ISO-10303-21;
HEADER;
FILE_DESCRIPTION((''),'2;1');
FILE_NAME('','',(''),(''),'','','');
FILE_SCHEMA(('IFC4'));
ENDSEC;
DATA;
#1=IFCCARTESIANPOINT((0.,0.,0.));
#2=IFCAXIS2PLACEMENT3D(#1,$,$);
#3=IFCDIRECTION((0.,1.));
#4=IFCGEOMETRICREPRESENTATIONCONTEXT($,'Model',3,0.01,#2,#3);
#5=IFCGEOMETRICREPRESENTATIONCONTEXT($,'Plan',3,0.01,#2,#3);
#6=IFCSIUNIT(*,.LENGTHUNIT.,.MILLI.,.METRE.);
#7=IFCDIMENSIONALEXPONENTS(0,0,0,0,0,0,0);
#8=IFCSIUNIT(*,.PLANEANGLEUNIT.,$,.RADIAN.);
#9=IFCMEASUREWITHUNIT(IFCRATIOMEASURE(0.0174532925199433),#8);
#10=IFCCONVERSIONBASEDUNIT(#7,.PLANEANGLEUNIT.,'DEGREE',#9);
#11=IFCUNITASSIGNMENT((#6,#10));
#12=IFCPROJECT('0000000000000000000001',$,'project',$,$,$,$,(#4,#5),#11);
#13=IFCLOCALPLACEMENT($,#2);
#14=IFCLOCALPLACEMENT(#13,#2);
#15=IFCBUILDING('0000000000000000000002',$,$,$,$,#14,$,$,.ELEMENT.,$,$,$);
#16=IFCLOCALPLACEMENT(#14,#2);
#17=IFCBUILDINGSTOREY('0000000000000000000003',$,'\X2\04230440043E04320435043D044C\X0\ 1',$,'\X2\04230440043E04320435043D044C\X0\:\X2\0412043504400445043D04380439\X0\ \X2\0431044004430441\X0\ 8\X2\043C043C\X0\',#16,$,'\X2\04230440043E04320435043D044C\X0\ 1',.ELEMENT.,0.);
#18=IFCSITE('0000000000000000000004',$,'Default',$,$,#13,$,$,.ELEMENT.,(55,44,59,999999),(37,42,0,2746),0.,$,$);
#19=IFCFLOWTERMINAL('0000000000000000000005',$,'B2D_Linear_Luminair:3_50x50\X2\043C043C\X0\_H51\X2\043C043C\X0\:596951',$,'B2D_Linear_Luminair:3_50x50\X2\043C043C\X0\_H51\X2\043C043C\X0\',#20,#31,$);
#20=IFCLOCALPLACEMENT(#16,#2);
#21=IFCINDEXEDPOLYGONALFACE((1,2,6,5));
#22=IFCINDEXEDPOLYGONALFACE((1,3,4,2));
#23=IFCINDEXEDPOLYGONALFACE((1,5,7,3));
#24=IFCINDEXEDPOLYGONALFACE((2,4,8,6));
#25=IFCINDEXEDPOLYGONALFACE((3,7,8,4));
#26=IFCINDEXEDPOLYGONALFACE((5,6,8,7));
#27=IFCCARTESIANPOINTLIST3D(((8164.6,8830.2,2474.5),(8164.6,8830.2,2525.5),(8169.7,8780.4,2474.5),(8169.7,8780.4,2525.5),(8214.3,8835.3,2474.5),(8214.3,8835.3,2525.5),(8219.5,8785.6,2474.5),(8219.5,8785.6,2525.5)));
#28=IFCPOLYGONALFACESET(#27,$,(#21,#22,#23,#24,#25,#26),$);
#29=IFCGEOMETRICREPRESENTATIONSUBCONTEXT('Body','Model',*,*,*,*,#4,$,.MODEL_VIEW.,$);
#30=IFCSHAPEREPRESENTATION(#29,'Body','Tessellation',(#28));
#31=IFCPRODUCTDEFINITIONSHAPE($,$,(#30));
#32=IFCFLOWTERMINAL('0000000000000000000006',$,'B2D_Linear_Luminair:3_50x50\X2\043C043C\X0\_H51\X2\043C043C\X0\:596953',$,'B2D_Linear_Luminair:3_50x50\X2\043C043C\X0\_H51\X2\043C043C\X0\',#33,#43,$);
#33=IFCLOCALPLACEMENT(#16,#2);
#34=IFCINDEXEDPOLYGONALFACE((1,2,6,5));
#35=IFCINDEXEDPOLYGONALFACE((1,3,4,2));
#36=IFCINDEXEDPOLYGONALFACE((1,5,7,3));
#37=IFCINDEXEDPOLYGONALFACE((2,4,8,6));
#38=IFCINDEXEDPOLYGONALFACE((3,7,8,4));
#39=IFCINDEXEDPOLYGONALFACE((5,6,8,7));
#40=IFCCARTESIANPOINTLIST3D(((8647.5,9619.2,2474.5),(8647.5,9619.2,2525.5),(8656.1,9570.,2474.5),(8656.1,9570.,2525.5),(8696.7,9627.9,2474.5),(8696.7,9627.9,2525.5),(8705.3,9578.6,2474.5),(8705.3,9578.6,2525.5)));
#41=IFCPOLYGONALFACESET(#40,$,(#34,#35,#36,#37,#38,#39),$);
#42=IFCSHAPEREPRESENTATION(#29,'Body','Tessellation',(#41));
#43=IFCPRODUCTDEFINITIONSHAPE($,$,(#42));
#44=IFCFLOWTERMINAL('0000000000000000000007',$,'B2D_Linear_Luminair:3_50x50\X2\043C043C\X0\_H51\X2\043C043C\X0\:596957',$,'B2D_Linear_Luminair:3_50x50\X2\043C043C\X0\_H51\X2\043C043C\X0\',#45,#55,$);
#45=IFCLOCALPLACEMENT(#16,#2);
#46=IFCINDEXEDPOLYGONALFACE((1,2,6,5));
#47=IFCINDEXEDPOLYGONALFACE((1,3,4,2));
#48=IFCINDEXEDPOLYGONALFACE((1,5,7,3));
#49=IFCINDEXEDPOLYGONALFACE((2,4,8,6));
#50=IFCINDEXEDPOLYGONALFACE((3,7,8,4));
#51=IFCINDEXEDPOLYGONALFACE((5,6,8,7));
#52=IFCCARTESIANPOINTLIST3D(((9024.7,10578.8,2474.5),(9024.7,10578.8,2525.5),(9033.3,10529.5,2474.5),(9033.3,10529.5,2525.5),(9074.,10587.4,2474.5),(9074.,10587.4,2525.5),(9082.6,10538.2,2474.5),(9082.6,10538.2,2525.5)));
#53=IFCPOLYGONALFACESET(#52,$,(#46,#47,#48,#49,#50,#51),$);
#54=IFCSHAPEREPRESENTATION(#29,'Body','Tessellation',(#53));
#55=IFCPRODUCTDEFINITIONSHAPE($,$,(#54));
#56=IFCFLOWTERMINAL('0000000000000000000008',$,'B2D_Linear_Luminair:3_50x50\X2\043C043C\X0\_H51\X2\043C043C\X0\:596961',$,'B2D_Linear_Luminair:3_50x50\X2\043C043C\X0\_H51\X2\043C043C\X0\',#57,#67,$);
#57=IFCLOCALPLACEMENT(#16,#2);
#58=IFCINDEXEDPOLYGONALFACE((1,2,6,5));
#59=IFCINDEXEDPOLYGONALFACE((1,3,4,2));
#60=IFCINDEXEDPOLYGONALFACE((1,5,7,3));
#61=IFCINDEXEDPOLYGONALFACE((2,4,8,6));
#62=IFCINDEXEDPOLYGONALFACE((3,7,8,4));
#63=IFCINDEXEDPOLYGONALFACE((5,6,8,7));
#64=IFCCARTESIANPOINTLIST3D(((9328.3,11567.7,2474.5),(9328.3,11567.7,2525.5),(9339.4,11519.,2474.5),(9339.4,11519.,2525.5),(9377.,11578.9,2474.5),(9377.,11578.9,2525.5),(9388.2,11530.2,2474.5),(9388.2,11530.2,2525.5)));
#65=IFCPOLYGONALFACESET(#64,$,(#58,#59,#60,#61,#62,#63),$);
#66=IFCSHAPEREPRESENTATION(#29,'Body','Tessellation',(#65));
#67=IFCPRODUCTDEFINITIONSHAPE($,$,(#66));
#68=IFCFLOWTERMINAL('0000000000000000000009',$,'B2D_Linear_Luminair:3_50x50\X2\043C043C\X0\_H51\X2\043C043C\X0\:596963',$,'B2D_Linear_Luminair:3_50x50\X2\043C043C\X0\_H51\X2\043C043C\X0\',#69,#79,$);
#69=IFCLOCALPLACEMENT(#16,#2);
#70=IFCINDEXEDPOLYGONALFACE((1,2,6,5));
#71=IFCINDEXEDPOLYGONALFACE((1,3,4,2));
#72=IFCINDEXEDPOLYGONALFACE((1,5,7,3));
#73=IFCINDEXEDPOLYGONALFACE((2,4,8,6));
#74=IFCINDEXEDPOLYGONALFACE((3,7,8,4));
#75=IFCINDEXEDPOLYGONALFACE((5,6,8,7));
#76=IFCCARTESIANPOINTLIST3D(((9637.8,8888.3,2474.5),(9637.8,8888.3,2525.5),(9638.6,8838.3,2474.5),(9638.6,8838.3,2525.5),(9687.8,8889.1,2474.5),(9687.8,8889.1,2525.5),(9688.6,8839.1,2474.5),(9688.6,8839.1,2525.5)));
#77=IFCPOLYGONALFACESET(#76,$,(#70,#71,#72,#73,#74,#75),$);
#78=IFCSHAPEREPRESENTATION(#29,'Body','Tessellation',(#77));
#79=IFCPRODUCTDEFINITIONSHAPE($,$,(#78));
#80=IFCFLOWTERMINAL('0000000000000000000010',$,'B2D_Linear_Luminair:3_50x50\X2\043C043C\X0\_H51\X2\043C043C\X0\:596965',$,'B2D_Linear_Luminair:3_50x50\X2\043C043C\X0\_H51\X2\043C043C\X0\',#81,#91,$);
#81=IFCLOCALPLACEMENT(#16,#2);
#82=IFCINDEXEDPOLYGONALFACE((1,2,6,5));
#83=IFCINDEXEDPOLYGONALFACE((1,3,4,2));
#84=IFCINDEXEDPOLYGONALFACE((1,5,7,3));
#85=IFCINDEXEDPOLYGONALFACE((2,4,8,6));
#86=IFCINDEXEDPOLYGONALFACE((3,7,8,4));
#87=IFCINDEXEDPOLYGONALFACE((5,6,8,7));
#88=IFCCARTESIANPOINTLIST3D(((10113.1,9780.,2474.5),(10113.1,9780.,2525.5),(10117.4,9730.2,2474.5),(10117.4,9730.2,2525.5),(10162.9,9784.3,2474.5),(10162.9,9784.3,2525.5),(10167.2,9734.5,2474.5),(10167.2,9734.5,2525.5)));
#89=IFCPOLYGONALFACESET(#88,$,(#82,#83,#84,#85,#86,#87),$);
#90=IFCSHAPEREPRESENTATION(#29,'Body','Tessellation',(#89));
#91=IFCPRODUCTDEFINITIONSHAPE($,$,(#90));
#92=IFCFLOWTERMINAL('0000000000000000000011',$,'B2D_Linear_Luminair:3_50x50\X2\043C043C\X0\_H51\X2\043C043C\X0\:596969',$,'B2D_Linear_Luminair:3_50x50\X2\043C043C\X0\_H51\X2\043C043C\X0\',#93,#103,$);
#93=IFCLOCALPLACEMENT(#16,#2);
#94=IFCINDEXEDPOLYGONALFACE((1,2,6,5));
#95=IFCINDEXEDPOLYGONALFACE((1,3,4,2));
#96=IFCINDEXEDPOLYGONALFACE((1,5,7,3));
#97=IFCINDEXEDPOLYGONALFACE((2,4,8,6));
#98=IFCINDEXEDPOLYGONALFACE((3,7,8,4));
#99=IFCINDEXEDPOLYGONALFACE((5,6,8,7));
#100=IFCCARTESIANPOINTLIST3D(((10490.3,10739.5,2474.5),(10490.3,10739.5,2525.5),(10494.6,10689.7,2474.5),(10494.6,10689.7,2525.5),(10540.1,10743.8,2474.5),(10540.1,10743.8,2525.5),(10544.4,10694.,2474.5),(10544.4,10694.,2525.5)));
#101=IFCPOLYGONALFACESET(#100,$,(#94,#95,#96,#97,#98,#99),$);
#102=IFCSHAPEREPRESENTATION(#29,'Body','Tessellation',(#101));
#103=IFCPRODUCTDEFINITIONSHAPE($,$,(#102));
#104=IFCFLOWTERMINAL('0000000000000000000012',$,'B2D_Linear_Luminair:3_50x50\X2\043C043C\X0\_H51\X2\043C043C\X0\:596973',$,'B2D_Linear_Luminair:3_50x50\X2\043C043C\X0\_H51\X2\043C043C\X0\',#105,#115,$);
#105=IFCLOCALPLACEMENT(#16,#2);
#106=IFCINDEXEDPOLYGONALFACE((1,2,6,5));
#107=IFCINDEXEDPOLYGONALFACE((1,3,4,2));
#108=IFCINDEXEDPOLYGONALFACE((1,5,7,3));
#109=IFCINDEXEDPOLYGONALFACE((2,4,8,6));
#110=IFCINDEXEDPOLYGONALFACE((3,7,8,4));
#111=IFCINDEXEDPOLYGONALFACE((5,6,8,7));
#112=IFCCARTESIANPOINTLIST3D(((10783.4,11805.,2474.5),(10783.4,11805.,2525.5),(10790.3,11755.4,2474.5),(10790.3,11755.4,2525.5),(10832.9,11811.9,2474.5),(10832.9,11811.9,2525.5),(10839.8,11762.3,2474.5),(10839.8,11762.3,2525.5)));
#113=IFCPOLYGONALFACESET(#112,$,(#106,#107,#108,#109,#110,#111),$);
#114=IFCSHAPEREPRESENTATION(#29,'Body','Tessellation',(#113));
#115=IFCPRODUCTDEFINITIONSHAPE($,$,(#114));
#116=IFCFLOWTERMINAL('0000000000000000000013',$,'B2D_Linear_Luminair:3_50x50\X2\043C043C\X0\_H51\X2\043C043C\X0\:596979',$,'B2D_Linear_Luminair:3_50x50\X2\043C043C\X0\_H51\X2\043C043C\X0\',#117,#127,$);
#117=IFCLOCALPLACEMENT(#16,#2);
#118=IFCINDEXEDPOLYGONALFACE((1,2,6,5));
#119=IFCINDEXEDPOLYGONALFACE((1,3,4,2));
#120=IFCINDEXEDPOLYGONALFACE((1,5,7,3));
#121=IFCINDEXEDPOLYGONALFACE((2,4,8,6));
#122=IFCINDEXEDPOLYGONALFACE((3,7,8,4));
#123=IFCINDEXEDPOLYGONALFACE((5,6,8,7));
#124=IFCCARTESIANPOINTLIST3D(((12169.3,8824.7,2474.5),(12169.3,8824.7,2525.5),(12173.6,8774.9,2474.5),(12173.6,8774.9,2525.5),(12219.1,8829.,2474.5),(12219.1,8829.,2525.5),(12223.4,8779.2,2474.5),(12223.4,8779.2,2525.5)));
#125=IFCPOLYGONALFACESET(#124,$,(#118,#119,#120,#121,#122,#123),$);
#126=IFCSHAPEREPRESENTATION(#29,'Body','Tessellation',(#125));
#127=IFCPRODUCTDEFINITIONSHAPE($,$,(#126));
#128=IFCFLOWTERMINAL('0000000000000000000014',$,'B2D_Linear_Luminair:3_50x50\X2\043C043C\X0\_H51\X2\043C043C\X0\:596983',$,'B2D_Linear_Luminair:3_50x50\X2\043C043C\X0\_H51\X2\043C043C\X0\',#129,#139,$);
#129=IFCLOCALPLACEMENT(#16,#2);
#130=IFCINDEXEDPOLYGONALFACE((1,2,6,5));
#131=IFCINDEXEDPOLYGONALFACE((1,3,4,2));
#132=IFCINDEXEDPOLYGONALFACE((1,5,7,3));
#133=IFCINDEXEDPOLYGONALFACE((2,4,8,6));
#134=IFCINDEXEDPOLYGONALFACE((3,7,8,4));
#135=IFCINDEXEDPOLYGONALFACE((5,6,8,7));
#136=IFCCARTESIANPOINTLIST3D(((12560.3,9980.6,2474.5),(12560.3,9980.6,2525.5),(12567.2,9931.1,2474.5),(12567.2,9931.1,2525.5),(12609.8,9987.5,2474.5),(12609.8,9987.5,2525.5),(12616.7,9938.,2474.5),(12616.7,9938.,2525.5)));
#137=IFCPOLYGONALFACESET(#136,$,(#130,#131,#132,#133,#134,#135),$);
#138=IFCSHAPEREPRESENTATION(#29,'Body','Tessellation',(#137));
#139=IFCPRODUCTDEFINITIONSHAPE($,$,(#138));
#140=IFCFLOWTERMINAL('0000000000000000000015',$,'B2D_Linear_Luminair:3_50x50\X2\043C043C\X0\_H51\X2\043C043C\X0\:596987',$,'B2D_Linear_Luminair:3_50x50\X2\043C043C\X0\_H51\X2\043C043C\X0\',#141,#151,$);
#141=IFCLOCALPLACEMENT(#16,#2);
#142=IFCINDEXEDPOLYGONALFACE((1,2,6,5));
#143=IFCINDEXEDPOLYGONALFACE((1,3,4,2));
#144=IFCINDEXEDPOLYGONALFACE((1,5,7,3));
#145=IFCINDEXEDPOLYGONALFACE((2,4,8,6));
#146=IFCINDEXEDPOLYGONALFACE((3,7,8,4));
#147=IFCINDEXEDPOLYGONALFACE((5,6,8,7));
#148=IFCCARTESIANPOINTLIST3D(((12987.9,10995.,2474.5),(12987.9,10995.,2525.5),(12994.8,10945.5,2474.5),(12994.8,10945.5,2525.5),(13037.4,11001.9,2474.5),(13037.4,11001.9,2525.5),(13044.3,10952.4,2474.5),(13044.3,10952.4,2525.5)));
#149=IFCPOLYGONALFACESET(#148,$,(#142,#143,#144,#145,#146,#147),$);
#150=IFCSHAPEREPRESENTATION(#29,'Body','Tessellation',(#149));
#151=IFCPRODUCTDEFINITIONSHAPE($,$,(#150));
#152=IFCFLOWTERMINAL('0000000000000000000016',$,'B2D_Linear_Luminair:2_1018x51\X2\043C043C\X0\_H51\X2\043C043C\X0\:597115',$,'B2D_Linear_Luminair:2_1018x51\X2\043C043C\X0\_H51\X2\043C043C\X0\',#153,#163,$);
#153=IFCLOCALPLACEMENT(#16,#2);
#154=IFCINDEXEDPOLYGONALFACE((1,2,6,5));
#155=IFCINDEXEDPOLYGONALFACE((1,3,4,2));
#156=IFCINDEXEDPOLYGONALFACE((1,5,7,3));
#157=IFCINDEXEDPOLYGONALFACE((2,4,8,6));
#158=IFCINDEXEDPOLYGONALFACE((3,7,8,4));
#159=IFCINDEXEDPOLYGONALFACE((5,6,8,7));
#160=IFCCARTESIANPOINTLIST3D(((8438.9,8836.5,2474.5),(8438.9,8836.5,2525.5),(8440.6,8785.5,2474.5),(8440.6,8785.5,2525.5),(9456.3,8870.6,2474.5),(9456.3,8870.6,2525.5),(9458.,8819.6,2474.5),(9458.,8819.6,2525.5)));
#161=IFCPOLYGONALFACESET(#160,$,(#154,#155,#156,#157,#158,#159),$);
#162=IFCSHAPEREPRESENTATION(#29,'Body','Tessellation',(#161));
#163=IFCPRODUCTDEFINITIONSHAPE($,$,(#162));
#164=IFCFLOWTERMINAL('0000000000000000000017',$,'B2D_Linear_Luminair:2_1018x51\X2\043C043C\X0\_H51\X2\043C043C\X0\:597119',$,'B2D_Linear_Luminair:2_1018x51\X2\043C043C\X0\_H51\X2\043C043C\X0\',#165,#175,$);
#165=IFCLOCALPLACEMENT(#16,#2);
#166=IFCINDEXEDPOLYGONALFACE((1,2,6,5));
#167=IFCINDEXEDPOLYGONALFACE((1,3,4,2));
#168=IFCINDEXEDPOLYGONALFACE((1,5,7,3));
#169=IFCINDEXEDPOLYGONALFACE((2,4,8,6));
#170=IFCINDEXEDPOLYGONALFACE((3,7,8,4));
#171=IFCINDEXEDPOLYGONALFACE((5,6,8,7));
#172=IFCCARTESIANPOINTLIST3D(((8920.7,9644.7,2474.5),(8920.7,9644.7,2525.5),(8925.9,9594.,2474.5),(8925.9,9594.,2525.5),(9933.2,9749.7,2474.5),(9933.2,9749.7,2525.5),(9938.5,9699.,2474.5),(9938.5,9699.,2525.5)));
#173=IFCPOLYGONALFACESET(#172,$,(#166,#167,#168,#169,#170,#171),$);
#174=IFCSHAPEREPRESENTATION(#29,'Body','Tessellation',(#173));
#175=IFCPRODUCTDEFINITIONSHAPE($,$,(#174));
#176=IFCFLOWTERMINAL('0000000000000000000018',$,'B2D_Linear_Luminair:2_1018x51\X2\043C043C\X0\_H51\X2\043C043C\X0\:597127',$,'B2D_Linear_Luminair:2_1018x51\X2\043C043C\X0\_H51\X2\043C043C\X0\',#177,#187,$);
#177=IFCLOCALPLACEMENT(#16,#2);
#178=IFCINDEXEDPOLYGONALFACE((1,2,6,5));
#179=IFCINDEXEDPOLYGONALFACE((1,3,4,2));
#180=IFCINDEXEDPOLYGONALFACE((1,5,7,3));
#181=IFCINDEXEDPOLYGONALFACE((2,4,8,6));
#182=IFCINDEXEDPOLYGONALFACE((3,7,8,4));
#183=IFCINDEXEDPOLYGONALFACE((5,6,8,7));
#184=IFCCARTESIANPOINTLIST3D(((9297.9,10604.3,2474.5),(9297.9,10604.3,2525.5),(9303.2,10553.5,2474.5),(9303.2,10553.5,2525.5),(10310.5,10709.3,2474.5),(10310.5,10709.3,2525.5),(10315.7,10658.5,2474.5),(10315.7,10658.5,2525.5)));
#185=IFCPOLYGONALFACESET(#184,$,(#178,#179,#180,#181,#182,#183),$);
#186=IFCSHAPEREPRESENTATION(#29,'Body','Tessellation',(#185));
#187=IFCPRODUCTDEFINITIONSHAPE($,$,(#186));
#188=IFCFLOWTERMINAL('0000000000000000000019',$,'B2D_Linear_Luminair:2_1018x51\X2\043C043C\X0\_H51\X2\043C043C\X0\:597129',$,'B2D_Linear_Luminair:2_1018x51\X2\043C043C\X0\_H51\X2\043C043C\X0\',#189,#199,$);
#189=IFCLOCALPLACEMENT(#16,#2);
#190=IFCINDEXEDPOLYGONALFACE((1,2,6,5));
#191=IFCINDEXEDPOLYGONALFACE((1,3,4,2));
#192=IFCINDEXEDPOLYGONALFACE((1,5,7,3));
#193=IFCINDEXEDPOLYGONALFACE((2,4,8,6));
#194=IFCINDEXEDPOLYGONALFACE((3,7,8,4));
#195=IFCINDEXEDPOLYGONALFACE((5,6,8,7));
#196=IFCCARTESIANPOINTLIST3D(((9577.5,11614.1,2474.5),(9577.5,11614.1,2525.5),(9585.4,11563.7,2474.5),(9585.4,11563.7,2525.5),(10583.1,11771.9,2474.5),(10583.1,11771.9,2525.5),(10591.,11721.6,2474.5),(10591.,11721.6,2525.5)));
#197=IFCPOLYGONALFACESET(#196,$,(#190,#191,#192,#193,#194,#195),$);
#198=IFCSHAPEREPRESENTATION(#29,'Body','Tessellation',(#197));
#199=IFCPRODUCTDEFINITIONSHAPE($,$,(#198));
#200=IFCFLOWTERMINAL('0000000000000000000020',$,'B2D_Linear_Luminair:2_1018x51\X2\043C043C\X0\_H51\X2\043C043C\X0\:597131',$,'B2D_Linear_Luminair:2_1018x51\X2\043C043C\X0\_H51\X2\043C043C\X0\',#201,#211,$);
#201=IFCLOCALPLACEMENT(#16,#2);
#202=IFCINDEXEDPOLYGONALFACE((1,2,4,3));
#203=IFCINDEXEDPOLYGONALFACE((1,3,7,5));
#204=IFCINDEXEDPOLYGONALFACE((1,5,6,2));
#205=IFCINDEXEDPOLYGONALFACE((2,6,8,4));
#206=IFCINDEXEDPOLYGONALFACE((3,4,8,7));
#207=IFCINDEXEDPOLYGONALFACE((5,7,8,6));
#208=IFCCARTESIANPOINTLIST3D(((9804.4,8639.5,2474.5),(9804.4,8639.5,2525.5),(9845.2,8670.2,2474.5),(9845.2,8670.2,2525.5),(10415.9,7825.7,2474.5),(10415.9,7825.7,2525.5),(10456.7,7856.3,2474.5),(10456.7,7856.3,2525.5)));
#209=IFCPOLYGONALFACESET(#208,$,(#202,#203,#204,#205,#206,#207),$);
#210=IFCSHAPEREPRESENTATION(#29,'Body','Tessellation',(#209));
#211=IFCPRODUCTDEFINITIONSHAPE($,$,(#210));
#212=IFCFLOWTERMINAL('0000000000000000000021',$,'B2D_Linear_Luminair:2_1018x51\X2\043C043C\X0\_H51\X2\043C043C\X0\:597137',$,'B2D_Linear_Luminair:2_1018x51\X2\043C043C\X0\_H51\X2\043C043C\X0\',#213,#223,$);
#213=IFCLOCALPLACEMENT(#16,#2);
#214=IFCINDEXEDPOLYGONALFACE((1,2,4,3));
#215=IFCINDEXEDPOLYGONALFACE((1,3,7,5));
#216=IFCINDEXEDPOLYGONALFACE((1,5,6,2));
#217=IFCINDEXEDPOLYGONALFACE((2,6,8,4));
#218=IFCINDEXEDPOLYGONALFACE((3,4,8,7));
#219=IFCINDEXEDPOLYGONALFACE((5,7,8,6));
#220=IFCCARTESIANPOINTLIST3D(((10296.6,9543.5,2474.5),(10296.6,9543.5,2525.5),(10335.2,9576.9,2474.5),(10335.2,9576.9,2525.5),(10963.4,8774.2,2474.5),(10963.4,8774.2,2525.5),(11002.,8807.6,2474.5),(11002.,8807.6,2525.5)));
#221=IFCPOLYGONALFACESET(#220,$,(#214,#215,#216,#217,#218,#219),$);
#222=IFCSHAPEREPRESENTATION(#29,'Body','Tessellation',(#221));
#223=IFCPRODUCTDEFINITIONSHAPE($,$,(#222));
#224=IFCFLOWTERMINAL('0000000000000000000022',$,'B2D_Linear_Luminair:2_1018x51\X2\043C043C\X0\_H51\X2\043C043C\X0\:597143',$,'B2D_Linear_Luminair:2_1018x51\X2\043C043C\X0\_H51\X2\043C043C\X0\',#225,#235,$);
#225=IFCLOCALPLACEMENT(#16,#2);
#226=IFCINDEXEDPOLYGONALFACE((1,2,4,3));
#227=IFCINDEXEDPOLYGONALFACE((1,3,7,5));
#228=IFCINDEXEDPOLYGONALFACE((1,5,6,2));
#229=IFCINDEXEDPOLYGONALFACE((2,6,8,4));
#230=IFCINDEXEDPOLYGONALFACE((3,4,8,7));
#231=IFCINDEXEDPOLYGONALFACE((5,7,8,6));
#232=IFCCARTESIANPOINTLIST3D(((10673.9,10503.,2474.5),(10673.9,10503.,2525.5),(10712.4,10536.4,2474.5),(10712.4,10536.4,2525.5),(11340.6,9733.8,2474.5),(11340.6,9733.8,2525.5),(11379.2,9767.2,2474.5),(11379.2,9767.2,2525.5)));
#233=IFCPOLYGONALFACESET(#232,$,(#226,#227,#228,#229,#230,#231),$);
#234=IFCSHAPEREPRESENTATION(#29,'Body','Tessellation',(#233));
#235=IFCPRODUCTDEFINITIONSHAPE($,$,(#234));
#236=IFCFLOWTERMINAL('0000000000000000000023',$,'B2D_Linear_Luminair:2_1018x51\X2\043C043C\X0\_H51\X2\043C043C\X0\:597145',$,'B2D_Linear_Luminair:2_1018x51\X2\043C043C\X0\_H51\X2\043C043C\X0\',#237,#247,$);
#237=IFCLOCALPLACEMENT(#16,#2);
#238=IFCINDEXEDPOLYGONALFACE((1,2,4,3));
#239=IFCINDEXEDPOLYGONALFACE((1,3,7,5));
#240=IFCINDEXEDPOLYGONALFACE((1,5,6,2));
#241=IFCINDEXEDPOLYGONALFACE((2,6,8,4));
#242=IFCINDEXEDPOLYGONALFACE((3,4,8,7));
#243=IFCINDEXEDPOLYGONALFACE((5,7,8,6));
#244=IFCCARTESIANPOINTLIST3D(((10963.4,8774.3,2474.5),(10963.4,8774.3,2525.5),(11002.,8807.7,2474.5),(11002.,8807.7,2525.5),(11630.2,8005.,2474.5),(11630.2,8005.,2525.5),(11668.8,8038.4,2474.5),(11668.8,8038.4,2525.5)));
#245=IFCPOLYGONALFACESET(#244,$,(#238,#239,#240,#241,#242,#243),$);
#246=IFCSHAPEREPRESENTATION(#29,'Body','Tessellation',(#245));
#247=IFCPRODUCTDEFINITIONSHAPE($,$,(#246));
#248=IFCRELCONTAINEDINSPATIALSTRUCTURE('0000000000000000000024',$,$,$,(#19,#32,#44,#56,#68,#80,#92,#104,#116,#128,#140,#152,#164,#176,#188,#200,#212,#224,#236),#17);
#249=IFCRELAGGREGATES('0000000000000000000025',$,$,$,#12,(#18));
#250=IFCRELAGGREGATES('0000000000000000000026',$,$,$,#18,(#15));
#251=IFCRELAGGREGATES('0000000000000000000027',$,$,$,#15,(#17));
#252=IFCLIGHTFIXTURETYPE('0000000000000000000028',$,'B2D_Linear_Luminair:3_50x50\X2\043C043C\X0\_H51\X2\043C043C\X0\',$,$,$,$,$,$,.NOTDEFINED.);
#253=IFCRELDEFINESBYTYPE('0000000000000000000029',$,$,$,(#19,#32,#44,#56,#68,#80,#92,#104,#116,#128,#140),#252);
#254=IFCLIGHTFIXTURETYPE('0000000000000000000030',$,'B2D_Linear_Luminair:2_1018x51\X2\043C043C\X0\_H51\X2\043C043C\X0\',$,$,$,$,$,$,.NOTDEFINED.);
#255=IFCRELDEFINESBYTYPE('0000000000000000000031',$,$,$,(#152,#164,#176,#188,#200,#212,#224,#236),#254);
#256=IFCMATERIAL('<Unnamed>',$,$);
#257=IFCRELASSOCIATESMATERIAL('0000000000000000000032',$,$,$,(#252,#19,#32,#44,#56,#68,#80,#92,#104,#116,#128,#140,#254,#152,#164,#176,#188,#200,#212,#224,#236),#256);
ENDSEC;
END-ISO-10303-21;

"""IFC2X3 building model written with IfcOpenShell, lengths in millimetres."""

from ifc_helpers import new_model, entity, si_unit, converted_unit, direction, frame, origin, origin_2d_with_axis, place, context, subcontext, project, spatial, rectangle, extrude, source, transform, mapped, material, type_object, type_shapes, element, save


model = new_model("IFC2X3")

# Units and contexts
model_context = context("Model", 3, precision=0.01, world=origin(), true_north=direction((0.0, 1.0)))
plan_context = context("Plan", 3, precision=0.01, world=origin(), true_north=direction((0.0, 1.0)))
body_context = subcontext(model_context, "Body", "Model", "MODEL_VIEW")
ifc_project = project(units=[si_unit("LENGTHUNIT", "METRE", prefix="MILLI"), converted_unit("PLANEANGLEUNIT", "DEGREE", entity("IfcRatioMeasure", 0.0174532925199433), si_unit("PLANEANGLEUNIT", "RADIAN"), dimensions=[0, 0, 0, 0, 0, 0, 0])], contexts=[model_context, plan_context])

# Site, building, storey
site_placement = place(None, origin())
site = spatial("IfcSite", under=ifc_project, at=site_placement, Name="Default", CompositionType="ELEMENT", RefLatitude=(55, 44, 59, 999999), RefLongitude=(37, 42, 0, 2746), RefElevation=0.0)
building_placement = place(site_placement, origin())
building = spatial("IfcBuilding", under=site, at=building_placement, CompositionType="ELEMENT")
storey_placement = place(building_placement, origin())
storey = spatial("IfcBuildingStorey", under=building, at=storey_placement, Name="Уровень 1", ObjectType="Уровень:Верхний брус 8мм", LongName="Уровень 1", CompositionType="ELEMENT", Elevation=0.0)

# Flow terminals
ifc_material = material(Name="<Unnamed>")
light_fixture_type_1 = type_object("IfcLightFixtureType", Name="B2D_Linear_Luminair:3_50x50мм_H51мм", PredefinedType="NOTDEFINED", material=ifc_material)
shared_shape_1 = source(origin(), body_context, "Body", "SweptSolid", [
    extrude(rectangle(XDim=50.0, YDim=50.0, at=origin_2d_with_axis()), frame((0.0, 0.0, 0.0), z_axis=(0.0, 0.0, 1.0), x_axis=(-1.0, 0.0, 0.0)), (0.0, 0.0, 1.0), 51.0),
])
type_shapes(light_fixture_type_1, [shared_shape_1])
for number, where, z_axis, x_axis, name in (
    (1, (8192.0, 8807.9, 2525.5), (0.0, 0.0, -1.0), (0.994667, 0.10314, 0.0), "B2D_Linear_Luminair:3_50x50мм_H51мм:596951"),
    (2, (8676.4, 9598.9, 2525.5), (0.0, 0.0, -1.0), (0.985049, 0.172273, 0.0), "B2D_Linear_Luminair:3_50x50мм_H51мм:596953"),
    (3, (9053.6, 10558.5, 2525.5), (0.0, 0.0, -1.0), (0.985049, 0.172273, 0.0), "B2D_Linear_Luminair:3_50x50мм_H51мм:596957"),
    (4, (9358.2, 11549.0, 2525.5), (0.0, 0.0, -1.0), (0.974683, 0.22359, 0.0), "B2D_Linear_Luminair:3_50x50мм_H51мм:596961"),
    (5, (9663.2, 8863.7, 2525.5), (0.0, 0.0, -1.0), (0.999871, 0.016056, 0.0), "B2D_Linear_Luminair:3_50x50мм_H51мм:596963"),
    (6, (10140.1, 9757.2, 2525.5), (0.0, 0.0, -1.0), (0.996315, 0.085765, 0.0), "B2D_Linear_Luminair:3_50x50мм_H51мм:596965"),
    (7, (10517.4, 10716.8, 2525.5), (0.0, 0.0, -1.0), (0.996315, 0.085765, 0.0), "B2D_Linear_Luminair:3_50x50мм_H51мм:596969"),
    (8, (10811.6, 11783.6, 2525.5), (0.0, 0.0, -1.0), (0.990461, 0.13779, 0.0), "B2D_Linear_Luminair:3_50x50мм_H51мм:596973"),
    (9, (12196.3, 8802.0, 2525.5), (0.0, 0.0, -1.0), (0.996315, 0.085765, 0.0), "B2D_Linear_Luminair:3_50x50мм_H51мм:596979"),
    (10, (12588.5, 9959.3, 2525.5), (0.0, 0.0, -1.0), (0.990461, 0.13779, 0.0), "B2D_Linear_Luminair:3_50x50мм_H51мм:596983"),
    (11, (13016.1, 10973.7, 2525.5), (0.0, 0.0, -1.0), (0.990461, 0.13779, 0.0), "B2D_Linear_Luminair:3_50x50мм_H51мм:596987"),
):
    element("IfcFlowTerminal", number, at=place(storey_placement, frame(where, z_axis=z_axis, x_axis=x_axis)), inside=storey, type_object=light_fixture_type_1, material=ifc_material, Name=name, ObjectType="B2D_Linear_Luminair:3_50x50мм_H51мм", context=body_context, shape_type="MappedRepresentation", body=[
        mapped(shared_shape_1, transform((0.0, 0.0, 0.0), scale=1.0)),
    ])
light_fixture_type_2 = type_object("IfcLightFixtureType", Name="B2D_Linear_Luminair:2_1018x51мм_H51мм", PredefinedType="NOTDEFINED", material=ifc_material)
shared_shape_2 = source(origin(), body_context, "Body", "SweptSolid", [
    extrude(rectangle(XDim=1018.0, YDim=51.0, at=origin_2d_with_axis()), frame((0.0, 0.0, 0.0), z_axis=(0.0, 0.0, 1.0), x_axis=(-1.0, 0.0, 0.0)), (0.0, 0.0, 1.0), 51.0),
])
type_shapes(light_fixture_type_2, [shared_shape_2])
for number, where, z_axis, x_axis, name in (
    (12, (8948.5, 8828.1, 2525.5), (0.0, 0.0, -1.0), (0.999439, 0.033504, 0.0), "B2D_Linear_Luminair:2_1018x51мм_H51мм:597115"),
    (13, (9429.6, 9671.8, 2525.5), (0.0, 0.0, -1.0), (0.994667, 0.10314, 0.0), "B2D_Linear_Luminair:2_1018x51мм_H51мм:597119"),
    (14, (9806.8, 10631.4, 2525.5), (0.0, 0.0, -1.0), (0.994667, 0.10314, 0.0), "B2D_Linear_Luminair:2_1018x51мм_H51мм:597127"),
    (15, (10084.2, 11667.8, 2525.5), (0.0, 0.0, -1.0), (0.987906, 0.155055, 0.0), "B2D_Linear_Luminair:2_1018x51мм_H51мм:597129"),
    (16, (10130.6, 8247.9, 2525.5), (0.0, 0.0, -1.0), (0.600699, -0.799475, 0.0), "B2D_Linear_Luminair:2_1018x51мм_H51мм:597131"),
    (17, (10649.3, 9175.6, 2525.5), (0.0, 0.0, -1.0), (0.655005, -0.755625, 0.0), "B2D_Linear_Luminair:2_1018x51мм_H51мм:597137"),
    (18, (11026.5, 10135.1, 2525.5), (0.0, 0.0, -1.0), (0.655005, -0.755625, 0.0), "B2D_Linear_Luminair:2_1018x51мм_H51мм:597143"),
    (19, (11316.1, 8406.3, 2525.5), (0.0, 0.0, -1.0), (0.655005, -0.755625, 0.0), "B2D_Linear_Luminair:2_1018x51мм_H51мм:597145"),
):
    element("IfcFlowTerminal", number, at=place(storey_placement, frame(where, z_axis=z_axis, x_axis=x_axis)), inside=storey, type_object=light_fixture_type_2, material=ifc_material, Name=name, ObjectType="B2D_Linear_Luminair:2_1018x51мм_H51мм", context=body_context, shape_type="MappedRepresentation", body=[
        mapped(shared_shape_2, transform((0.0, 0.0, 0.0), scale=1.0)),
    ])

save(model, "model.ifc")
